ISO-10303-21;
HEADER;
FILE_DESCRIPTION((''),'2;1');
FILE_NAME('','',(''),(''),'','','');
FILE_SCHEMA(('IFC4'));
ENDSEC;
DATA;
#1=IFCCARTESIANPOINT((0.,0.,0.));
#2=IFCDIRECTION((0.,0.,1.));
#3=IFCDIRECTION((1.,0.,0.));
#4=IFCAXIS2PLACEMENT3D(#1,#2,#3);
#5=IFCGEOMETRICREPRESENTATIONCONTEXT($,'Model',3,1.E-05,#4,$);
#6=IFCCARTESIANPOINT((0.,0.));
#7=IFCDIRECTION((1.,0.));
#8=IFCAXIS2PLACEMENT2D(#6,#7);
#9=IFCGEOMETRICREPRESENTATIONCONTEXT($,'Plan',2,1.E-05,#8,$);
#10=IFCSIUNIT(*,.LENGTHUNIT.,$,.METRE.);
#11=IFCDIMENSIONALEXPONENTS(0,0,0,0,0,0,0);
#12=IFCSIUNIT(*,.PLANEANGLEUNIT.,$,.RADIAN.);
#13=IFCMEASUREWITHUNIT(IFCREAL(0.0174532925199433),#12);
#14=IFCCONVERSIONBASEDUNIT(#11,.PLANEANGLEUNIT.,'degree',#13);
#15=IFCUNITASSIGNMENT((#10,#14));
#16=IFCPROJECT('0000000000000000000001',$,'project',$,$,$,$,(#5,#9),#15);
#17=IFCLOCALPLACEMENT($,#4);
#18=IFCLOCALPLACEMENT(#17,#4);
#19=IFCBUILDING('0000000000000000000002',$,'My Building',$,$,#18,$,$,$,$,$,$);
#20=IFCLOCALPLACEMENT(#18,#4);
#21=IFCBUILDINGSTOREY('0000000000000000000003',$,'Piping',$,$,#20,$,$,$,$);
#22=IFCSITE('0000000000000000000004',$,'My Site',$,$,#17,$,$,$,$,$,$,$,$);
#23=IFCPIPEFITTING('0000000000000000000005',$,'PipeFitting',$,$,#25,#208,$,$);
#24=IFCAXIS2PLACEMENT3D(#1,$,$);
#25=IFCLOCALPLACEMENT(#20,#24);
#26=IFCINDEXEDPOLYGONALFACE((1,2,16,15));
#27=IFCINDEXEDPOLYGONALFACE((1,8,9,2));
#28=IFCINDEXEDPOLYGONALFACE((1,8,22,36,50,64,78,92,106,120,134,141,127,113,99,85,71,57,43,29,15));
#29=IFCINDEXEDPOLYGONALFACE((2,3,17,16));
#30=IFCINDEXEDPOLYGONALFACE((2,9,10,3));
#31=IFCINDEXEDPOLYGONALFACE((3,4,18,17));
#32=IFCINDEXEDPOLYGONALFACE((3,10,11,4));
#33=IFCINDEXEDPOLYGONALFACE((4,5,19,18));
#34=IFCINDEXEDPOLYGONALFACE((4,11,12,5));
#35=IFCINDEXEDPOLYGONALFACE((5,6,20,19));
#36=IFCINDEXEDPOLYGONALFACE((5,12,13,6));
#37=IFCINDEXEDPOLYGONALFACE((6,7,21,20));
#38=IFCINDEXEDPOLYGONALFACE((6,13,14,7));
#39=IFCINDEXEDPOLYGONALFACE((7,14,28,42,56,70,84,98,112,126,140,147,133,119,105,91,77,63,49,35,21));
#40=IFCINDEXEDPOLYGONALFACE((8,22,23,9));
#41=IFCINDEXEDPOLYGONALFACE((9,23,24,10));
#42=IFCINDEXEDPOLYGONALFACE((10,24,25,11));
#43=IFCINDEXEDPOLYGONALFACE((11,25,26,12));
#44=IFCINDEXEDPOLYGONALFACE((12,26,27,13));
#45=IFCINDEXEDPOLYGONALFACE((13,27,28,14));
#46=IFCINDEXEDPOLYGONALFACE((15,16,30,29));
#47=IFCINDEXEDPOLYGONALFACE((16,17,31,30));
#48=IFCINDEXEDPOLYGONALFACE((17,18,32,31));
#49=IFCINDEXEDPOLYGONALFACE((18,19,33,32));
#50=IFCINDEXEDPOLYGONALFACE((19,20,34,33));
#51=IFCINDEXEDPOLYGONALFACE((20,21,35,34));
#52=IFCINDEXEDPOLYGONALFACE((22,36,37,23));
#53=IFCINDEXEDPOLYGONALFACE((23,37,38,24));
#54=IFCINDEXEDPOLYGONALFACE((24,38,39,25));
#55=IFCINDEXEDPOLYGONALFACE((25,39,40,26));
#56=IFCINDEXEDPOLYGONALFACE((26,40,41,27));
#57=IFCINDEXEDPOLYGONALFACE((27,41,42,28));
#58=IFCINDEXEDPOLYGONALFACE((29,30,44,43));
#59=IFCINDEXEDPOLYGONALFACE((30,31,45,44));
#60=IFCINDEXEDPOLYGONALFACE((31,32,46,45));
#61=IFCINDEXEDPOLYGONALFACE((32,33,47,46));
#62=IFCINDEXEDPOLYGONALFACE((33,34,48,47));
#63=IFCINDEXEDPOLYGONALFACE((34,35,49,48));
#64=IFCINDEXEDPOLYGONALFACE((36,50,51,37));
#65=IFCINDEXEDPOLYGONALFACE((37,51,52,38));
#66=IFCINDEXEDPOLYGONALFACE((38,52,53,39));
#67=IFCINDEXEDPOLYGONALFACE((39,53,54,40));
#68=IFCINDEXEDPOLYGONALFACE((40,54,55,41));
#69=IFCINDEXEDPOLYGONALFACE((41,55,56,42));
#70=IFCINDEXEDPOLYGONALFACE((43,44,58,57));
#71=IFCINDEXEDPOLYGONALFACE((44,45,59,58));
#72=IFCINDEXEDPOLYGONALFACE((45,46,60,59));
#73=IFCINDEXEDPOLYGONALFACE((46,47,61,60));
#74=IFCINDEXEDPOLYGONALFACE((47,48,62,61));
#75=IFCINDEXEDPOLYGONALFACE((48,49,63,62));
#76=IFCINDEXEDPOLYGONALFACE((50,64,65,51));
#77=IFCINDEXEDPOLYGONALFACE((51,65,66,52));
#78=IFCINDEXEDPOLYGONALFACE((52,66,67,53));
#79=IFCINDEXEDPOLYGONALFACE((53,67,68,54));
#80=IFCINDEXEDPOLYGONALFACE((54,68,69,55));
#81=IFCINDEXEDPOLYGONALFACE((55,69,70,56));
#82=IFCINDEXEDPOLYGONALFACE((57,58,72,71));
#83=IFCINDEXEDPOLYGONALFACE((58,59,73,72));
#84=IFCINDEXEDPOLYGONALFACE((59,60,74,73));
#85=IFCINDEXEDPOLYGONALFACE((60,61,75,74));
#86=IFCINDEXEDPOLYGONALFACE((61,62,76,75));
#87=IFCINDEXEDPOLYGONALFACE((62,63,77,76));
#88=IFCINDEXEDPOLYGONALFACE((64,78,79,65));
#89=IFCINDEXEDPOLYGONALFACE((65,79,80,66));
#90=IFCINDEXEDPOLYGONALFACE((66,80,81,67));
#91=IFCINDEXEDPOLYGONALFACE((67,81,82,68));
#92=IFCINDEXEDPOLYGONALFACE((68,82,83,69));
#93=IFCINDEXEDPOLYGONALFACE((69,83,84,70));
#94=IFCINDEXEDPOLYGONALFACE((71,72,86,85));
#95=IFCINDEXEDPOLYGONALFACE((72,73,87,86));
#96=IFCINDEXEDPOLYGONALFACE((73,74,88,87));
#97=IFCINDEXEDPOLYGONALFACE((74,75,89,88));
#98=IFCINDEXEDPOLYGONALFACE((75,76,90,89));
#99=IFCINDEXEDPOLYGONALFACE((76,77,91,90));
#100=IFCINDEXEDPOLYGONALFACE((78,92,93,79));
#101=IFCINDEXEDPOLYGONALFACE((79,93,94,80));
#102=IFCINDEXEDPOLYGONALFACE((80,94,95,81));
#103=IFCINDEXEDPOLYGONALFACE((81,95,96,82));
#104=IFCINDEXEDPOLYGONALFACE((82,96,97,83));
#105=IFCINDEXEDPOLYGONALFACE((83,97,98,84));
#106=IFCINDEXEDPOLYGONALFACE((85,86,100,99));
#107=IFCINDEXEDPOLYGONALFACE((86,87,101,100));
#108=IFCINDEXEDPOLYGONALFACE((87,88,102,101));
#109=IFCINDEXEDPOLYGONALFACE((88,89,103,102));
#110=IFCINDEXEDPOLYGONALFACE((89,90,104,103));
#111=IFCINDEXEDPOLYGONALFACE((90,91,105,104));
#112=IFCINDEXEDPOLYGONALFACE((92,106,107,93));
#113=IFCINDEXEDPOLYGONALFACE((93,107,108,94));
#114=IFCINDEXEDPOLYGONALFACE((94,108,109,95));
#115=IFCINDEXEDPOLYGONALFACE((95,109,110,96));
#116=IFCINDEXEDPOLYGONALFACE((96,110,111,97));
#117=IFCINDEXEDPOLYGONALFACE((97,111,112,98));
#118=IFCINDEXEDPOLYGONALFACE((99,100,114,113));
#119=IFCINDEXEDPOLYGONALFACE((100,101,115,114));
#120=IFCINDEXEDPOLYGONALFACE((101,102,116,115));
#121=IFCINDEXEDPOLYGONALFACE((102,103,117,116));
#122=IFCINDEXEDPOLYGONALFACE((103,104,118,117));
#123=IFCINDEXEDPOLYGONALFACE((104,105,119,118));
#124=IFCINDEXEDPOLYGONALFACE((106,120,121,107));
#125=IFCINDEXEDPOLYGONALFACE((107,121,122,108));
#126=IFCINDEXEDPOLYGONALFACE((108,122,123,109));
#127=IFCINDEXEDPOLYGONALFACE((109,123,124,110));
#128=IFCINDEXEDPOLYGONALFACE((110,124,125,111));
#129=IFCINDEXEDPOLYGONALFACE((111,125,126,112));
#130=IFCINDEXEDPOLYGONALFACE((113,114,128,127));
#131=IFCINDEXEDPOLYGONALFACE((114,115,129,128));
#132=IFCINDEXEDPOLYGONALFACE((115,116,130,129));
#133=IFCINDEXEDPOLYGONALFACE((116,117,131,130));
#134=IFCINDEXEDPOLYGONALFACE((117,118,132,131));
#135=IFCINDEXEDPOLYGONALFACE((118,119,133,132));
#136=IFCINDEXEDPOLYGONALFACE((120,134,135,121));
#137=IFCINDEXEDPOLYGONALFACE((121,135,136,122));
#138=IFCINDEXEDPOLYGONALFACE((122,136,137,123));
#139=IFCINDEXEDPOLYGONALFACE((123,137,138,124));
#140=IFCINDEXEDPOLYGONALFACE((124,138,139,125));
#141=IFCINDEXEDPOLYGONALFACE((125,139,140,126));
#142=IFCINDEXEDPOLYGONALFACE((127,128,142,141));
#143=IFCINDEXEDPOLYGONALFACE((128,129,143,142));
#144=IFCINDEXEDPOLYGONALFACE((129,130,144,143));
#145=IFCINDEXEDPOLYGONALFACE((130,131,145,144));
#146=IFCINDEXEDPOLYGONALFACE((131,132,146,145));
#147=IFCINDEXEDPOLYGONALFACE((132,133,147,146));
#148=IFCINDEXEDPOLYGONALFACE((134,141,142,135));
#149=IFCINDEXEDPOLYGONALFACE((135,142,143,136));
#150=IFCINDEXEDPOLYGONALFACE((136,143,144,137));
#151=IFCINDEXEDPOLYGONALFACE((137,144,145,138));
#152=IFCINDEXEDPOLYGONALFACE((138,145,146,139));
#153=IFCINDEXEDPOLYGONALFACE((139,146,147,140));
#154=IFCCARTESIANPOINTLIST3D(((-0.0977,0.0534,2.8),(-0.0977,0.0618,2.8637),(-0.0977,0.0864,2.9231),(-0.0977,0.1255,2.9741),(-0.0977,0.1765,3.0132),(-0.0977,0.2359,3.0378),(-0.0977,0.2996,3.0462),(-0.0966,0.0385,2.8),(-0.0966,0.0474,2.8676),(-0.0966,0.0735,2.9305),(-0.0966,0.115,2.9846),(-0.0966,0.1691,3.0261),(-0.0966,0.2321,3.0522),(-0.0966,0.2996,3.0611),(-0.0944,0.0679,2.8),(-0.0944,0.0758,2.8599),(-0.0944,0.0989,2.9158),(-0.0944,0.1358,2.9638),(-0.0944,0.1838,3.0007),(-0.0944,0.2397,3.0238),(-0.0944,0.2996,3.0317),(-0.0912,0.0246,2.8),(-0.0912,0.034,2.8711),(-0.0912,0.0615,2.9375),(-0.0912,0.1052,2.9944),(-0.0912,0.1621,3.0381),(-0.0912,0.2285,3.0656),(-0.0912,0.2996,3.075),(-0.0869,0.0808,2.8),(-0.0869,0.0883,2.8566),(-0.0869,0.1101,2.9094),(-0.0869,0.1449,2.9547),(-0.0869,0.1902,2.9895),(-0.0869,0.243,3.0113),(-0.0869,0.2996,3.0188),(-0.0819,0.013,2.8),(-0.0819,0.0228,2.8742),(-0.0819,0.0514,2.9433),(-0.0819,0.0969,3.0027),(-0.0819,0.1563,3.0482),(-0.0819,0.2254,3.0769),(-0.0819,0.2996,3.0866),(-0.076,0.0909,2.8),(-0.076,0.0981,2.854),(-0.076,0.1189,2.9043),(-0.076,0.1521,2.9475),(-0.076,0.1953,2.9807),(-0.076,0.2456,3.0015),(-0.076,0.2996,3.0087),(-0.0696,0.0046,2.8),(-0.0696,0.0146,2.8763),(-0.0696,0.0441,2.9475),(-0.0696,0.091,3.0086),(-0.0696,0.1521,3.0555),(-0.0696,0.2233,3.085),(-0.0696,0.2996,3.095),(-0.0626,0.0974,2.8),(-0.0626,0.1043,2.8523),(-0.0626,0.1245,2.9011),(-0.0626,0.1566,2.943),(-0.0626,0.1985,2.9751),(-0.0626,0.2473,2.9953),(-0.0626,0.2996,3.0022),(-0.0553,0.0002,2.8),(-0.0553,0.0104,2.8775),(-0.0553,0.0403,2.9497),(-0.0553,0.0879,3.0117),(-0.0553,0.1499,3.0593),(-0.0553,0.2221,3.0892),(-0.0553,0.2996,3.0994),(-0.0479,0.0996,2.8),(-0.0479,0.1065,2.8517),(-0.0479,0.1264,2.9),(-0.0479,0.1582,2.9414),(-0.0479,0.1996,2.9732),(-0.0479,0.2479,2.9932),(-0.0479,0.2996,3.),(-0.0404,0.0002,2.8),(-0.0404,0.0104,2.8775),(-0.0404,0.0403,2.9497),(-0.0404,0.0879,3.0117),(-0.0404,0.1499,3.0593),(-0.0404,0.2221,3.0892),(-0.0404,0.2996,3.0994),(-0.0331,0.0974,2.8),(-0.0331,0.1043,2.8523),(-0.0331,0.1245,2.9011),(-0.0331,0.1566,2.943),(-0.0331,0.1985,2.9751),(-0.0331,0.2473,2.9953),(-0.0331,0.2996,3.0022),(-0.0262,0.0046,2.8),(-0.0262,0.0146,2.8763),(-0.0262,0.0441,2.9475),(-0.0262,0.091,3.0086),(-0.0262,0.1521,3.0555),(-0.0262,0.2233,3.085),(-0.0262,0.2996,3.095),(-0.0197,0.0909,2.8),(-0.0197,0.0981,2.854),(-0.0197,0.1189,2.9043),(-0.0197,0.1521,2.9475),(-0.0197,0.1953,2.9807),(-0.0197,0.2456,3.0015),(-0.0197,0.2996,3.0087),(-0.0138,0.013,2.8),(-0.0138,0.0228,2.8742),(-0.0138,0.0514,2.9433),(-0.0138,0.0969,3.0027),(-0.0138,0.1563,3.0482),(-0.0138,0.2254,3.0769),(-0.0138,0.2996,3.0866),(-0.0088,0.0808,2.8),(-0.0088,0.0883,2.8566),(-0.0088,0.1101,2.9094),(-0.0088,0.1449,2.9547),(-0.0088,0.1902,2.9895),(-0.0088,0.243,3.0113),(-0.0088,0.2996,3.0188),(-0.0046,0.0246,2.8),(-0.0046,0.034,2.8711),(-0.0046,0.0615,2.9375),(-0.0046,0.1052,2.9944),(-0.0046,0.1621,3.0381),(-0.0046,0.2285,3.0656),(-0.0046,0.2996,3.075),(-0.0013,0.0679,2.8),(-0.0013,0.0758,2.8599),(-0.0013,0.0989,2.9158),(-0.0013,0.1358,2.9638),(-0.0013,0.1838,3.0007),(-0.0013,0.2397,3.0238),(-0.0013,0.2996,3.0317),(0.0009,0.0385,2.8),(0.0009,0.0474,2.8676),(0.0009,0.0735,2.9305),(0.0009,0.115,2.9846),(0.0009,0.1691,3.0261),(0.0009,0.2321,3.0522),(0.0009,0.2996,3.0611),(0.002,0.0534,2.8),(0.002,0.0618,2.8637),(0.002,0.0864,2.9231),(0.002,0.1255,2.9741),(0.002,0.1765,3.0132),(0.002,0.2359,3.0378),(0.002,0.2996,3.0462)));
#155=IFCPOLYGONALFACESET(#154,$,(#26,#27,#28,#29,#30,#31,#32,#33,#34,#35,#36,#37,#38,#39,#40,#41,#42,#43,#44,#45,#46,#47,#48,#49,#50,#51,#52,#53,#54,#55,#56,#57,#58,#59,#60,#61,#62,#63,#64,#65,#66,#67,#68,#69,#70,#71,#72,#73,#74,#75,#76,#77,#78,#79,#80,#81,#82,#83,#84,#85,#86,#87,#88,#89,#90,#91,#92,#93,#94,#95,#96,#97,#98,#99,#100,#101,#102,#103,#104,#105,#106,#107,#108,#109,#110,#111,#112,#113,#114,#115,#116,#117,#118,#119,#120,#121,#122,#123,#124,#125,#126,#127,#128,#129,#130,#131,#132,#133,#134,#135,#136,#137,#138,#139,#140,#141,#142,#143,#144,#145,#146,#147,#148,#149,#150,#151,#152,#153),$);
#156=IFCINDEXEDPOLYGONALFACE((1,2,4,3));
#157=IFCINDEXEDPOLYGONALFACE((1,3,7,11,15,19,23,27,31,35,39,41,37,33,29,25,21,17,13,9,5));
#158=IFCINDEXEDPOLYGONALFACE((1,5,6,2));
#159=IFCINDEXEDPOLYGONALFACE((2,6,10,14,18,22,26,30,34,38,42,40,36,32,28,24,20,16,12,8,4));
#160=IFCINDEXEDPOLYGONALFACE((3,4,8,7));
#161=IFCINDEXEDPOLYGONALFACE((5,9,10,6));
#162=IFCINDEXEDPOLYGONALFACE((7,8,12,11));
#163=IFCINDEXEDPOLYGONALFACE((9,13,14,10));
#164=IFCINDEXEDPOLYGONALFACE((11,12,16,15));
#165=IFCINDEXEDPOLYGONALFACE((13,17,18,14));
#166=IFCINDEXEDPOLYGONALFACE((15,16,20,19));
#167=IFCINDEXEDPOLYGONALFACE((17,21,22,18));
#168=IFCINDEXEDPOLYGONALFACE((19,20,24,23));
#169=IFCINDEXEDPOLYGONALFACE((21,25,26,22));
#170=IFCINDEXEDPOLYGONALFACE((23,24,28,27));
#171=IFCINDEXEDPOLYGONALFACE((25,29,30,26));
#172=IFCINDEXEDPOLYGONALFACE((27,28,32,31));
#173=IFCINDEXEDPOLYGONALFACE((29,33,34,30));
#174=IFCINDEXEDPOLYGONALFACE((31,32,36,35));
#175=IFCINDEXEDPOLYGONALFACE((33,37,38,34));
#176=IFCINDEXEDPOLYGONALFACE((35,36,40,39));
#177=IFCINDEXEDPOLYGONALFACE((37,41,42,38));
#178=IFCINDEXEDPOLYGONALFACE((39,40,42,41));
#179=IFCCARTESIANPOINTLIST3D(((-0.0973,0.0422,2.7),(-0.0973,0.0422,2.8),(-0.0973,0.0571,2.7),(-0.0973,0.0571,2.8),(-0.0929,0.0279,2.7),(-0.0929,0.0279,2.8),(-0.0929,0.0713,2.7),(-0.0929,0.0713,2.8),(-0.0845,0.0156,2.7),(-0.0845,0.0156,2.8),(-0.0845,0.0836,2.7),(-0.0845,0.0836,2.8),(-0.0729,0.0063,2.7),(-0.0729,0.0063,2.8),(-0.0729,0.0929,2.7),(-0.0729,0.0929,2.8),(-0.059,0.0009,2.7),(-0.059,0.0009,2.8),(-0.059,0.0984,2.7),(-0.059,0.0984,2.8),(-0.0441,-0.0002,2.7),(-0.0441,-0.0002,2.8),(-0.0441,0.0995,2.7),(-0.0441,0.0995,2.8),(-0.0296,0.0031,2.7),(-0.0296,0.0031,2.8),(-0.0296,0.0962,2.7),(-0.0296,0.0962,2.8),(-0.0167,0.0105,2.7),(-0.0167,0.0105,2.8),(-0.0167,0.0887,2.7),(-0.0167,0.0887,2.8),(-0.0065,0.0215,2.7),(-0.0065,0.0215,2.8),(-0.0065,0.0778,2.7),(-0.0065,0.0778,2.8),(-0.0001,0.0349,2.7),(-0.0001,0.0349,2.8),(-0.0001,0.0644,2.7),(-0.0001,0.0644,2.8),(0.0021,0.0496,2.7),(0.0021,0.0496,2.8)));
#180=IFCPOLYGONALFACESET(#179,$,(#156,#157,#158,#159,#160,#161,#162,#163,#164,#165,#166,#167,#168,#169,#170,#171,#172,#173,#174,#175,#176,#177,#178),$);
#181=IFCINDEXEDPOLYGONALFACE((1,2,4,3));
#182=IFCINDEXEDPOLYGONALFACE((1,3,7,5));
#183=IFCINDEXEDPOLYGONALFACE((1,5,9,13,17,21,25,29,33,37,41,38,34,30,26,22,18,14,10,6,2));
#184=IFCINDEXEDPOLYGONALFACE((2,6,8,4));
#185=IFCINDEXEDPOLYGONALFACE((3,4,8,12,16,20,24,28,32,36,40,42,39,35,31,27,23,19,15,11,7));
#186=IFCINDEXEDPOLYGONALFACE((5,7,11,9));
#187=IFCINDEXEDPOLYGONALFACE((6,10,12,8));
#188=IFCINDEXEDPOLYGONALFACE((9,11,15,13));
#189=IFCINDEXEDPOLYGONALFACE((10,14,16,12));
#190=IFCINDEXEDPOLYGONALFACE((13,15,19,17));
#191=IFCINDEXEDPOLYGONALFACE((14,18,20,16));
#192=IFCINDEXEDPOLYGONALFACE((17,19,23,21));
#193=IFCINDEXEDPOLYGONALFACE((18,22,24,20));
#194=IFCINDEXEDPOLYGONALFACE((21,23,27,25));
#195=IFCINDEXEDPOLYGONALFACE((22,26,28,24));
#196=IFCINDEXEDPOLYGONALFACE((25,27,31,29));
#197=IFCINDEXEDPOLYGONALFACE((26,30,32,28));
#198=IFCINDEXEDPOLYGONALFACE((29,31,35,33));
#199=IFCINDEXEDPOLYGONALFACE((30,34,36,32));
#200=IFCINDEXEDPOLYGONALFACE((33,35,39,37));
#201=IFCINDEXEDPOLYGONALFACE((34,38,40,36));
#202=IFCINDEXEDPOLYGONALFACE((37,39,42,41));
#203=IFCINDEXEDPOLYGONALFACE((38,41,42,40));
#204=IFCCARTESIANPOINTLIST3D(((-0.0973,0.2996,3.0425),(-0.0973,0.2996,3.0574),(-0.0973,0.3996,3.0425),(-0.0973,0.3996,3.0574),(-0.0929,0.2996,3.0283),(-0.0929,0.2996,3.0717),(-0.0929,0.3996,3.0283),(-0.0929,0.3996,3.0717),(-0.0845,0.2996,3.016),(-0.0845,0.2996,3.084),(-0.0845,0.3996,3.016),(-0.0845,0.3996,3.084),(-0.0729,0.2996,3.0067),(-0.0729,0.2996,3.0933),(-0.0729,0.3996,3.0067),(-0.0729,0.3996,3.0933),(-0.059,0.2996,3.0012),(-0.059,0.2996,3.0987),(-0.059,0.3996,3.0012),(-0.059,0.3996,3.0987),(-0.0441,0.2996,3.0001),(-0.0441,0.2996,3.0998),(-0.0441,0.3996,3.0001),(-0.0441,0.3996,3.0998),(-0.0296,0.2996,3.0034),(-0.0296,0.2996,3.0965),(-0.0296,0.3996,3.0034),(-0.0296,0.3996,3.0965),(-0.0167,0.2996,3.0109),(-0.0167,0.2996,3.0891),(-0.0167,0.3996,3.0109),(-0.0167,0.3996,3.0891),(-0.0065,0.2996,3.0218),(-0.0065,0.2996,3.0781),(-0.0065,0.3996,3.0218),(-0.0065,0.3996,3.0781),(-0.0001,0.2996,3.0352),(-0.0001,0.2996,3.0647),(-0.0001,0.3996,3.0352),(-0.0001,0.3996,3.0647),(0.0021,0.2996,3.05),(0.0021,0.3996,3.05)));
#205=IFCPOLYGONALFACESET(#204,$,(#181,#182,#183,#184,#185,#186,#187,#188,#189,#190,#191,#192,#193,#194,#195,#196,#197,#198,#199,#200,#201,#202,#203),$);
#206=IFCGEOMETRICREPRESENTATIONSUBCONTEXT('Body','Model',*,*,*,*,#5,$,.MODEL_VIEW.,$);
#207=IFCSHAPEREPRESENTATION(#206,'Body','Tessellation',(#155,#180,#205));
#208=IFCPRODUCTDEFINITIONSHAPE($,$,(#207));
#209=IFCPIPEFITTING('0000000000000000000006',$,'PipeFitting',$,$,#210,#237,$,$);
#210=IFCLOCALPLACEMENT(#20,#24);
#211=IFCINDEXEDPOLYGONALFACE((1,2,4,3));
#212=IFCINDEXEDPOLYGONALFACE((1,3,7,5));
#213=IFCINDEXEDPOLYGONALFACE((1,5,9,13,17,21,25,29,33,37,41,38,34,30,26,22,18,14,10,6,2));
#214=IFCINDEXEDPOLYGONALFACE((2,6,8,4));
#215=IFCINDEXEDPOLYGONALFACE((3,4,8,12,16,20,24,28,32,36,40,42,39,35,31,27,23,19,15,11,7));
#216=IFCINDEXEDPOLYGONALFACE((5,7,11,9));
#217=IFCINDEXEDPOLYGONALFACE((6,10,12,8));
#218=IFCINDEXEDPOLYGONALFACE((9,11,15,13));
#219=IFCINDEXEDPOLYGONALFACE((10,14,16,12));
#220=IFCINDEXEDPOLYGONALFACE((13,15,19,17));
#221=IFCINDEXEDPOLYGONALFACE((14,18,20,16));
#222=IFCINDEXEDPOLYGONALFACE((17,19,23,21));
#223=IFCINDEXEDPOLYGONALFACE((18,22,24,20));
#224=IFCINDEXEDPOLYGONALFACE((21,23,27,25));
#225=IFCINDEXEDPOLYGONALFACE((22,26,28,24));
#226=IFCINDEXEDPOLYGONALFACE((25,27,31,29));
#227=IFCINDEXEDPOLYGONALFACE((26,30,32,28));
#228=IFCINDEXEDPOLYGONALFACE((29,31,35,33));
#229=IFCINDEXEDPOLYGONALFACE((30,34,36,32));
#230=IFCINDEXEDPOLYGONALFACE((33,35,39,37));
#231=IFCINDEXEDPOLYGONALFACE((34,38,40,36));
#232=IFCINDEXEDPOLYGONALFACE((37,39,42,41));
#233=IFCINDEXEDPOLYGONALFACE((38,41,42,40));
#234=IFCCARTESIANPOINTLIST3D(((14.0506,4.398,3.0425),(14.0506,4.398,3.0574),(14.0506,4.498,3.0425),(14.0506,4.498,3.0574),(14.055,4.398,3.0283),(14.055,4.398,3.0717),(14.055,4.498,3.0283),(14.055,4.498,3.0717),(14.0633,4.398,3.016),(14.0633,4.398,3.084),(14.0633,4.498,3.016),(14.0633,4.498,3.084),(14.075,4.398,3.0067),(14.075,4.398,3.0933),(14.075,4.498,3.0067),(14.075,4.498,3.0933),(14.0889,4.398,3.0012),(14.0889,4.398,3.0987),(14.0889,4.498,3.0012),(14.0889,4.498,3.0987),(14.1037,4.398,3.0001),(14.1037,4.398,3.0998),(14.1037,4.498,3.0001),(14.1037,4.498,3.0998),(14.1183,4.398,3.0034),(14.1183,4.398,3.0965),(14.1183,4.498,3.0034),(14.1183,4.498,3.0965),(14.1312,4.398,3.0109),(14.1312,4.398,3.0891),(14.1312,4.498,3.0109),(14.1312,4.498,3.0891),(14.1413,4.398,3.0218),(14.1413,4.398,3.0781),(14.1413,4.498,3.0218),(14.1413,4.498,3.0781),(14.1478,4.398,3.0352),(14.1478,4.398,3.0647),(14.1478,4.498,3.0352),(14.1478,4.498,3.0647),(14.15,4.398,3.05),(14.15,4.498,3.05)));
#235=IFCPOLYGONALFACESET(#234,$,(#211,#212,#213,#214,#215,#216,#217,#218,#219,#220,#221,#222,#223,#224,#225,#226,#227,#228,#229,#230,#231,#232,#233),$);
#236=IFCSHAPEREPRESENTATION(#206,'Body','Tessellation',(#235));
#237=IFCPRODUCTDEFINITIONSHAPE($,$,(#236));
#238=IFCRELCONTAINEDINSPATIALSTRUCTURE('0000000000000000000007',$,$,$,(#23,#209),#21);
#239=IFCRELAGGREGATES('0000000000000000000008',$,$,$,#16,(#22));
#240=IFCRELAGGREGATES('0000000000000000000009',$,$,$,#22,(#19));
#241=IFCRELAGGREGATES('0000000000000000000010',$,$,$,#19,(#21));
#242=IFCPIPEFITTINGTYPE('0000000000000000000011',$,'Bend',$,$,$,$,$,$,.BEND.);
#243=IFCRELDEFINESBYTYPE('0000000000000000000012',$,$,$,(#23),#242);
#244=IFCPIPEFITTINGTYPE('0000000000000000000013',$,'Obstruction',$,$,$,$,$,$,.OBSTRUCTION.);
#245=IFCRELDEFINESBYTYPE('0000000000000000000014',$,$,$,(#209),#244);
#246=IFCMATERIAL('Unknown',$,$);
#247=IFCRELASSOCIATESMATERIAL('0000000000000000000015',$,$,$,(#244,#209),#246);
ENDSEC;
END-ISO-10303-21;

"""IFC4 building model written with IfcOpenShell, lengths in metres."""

from ifc_helpers import new_model, entity, si_unit, converted_unit, frame, origin_with_axes, origin_2d_with_axis, place, context, subcontext, project, spatial, circle, extrude, source, transform, mapped, material, material_profile, profile_set, profile_usage, type_object, type_shapes, element, save


model = new_model("IFC4")

# Units and contexts
model_context = context("Model", 3, precision=1e-05, world=origin_with_axes())
plan_context = context("Plan", 2, precision=1e-05, world=origin_2d_with_axis())
body_context = subcontext(model_context, "Body", "Model", "MODEL_VIEW")
ifc_project = project(units=[si_unit("LENGTHUNIT", "METRE"), converted_unit("PLANEANGLEUNIT", "degree", entity("IfcReal", 0.0174532925199433), si_unit("PLANEANGLEUNIT", "RADIAN"), dimensions=[0, 0, 0, 0, 0, 0, 0])], contexts=[model_context, plan_context])

# Site, building, storey
site_placement = place(None, origin_with_axes())
site = spatial("IfcSite", under=ifc_project, at=site_placement, Name="My Site")
building_placement = place(site_placement, origin_with_axes())
building = spatial("IfcBuilding", under=site, at=building_placement, Name="My Building")
storey_placement = place(building_placement, origin_with_axes())
storey = spatial("IfcBuildingStorey", under=building, at=storey_placement, Name="Piping")

# Shared definitions
ifc_material = material(Name="Unknown")

# Pipe fittings
pipe_fitting_type_1 = type_object("IfcPipeFittingType", Name="Bend", PredefinedType="BEND")
shared_shape = source(origin_with_axes(), body_context, "Body", "SolidModel", [
    entity("IfcSweptDiskSolid", entity("IfcIndexedPolyCurve", entity("IfcCartesianPointList3D", [[0.0, 0.0, -0.1], [0.0, -0.0732, -0.2768], [0.0, -0.25, -0.35]]), [entity("IfcArcIndex", [1, 2, 3])]), 0.05),
    extrude(circle(Radius=0.05), origin_with_axes(), (0.0, 0.0, -1.0), 0.1),
    extrude(circle(Radius=0.05), frame((0.0, -0.25, -0.35), z_axis=(0.0, -1.0, 0.0), x_axis=(1.0, 0.0, 0.0)), (0.0, 0.0, 1.0), 0.1),
])
type_shapes(pipe_fitting_type_1, [shared_shape])
for number, where, z_axis, x_axis, name in (
    (1, (-0.0479, 0.0496, 2.7), (0.0, 0.0, -1.0), (1.0, 0.0, 0.0), "PipeFitting"),
):
    element("IfcPipeFitting", number, at=place(storey_placement, frame(where, z_axis=z_axis, x_axis=x_axis)), inside=storey, type_object=pipe_fitting_type_1, Name=name, context=body_context, shape_type="MappedRepresentation", body=[
        mapped(shared_shape, transform((0.0, 0.0, 0.0), x_axis=(1.0, 0.0, 0.0), y_axis=(0.0, 1.0, 0.0), z_axis=(0.0, 0.0, 1.0), scale=1.0)),
    ])
ifc_material_profile_1 = material_profile(ifc_material, circle(Radius=0.05))
ifc_profile_set_1 = profile_set([ifc_material_profile_1])
ifc_profile_usage_1 = profile_usage(ifc_profile_set_1, cardinal=5)
pipe_fitting_type_2 = type_object("IfcPipeFittingType", Name="Obstruction", PredefinedType="OBSTRUCTION", material=ifc_profile_set_1)
pipe_fitting_1_placement = place(storey_placement, frame((14.1, 4.398, 3.05), z_axis=(0.0, 1.0, -0.000001), x_axis=(1.0, 0.0, 0.000001)))
element("IfcPipeFitting", 2, at=pipe_fitting_1_placement, inside=storey, type_object=pipe_fitting_type_2, material=ifc_profile_usage_1, Name="PipeFitting", context=body_context, shape_type="SweptSolid", body=[
    extrude(circle(Radius=0.05), origin_with_axes(), (0.0, 0.0, 1.0), 0.1),
])

save(model, "model.ifc")
